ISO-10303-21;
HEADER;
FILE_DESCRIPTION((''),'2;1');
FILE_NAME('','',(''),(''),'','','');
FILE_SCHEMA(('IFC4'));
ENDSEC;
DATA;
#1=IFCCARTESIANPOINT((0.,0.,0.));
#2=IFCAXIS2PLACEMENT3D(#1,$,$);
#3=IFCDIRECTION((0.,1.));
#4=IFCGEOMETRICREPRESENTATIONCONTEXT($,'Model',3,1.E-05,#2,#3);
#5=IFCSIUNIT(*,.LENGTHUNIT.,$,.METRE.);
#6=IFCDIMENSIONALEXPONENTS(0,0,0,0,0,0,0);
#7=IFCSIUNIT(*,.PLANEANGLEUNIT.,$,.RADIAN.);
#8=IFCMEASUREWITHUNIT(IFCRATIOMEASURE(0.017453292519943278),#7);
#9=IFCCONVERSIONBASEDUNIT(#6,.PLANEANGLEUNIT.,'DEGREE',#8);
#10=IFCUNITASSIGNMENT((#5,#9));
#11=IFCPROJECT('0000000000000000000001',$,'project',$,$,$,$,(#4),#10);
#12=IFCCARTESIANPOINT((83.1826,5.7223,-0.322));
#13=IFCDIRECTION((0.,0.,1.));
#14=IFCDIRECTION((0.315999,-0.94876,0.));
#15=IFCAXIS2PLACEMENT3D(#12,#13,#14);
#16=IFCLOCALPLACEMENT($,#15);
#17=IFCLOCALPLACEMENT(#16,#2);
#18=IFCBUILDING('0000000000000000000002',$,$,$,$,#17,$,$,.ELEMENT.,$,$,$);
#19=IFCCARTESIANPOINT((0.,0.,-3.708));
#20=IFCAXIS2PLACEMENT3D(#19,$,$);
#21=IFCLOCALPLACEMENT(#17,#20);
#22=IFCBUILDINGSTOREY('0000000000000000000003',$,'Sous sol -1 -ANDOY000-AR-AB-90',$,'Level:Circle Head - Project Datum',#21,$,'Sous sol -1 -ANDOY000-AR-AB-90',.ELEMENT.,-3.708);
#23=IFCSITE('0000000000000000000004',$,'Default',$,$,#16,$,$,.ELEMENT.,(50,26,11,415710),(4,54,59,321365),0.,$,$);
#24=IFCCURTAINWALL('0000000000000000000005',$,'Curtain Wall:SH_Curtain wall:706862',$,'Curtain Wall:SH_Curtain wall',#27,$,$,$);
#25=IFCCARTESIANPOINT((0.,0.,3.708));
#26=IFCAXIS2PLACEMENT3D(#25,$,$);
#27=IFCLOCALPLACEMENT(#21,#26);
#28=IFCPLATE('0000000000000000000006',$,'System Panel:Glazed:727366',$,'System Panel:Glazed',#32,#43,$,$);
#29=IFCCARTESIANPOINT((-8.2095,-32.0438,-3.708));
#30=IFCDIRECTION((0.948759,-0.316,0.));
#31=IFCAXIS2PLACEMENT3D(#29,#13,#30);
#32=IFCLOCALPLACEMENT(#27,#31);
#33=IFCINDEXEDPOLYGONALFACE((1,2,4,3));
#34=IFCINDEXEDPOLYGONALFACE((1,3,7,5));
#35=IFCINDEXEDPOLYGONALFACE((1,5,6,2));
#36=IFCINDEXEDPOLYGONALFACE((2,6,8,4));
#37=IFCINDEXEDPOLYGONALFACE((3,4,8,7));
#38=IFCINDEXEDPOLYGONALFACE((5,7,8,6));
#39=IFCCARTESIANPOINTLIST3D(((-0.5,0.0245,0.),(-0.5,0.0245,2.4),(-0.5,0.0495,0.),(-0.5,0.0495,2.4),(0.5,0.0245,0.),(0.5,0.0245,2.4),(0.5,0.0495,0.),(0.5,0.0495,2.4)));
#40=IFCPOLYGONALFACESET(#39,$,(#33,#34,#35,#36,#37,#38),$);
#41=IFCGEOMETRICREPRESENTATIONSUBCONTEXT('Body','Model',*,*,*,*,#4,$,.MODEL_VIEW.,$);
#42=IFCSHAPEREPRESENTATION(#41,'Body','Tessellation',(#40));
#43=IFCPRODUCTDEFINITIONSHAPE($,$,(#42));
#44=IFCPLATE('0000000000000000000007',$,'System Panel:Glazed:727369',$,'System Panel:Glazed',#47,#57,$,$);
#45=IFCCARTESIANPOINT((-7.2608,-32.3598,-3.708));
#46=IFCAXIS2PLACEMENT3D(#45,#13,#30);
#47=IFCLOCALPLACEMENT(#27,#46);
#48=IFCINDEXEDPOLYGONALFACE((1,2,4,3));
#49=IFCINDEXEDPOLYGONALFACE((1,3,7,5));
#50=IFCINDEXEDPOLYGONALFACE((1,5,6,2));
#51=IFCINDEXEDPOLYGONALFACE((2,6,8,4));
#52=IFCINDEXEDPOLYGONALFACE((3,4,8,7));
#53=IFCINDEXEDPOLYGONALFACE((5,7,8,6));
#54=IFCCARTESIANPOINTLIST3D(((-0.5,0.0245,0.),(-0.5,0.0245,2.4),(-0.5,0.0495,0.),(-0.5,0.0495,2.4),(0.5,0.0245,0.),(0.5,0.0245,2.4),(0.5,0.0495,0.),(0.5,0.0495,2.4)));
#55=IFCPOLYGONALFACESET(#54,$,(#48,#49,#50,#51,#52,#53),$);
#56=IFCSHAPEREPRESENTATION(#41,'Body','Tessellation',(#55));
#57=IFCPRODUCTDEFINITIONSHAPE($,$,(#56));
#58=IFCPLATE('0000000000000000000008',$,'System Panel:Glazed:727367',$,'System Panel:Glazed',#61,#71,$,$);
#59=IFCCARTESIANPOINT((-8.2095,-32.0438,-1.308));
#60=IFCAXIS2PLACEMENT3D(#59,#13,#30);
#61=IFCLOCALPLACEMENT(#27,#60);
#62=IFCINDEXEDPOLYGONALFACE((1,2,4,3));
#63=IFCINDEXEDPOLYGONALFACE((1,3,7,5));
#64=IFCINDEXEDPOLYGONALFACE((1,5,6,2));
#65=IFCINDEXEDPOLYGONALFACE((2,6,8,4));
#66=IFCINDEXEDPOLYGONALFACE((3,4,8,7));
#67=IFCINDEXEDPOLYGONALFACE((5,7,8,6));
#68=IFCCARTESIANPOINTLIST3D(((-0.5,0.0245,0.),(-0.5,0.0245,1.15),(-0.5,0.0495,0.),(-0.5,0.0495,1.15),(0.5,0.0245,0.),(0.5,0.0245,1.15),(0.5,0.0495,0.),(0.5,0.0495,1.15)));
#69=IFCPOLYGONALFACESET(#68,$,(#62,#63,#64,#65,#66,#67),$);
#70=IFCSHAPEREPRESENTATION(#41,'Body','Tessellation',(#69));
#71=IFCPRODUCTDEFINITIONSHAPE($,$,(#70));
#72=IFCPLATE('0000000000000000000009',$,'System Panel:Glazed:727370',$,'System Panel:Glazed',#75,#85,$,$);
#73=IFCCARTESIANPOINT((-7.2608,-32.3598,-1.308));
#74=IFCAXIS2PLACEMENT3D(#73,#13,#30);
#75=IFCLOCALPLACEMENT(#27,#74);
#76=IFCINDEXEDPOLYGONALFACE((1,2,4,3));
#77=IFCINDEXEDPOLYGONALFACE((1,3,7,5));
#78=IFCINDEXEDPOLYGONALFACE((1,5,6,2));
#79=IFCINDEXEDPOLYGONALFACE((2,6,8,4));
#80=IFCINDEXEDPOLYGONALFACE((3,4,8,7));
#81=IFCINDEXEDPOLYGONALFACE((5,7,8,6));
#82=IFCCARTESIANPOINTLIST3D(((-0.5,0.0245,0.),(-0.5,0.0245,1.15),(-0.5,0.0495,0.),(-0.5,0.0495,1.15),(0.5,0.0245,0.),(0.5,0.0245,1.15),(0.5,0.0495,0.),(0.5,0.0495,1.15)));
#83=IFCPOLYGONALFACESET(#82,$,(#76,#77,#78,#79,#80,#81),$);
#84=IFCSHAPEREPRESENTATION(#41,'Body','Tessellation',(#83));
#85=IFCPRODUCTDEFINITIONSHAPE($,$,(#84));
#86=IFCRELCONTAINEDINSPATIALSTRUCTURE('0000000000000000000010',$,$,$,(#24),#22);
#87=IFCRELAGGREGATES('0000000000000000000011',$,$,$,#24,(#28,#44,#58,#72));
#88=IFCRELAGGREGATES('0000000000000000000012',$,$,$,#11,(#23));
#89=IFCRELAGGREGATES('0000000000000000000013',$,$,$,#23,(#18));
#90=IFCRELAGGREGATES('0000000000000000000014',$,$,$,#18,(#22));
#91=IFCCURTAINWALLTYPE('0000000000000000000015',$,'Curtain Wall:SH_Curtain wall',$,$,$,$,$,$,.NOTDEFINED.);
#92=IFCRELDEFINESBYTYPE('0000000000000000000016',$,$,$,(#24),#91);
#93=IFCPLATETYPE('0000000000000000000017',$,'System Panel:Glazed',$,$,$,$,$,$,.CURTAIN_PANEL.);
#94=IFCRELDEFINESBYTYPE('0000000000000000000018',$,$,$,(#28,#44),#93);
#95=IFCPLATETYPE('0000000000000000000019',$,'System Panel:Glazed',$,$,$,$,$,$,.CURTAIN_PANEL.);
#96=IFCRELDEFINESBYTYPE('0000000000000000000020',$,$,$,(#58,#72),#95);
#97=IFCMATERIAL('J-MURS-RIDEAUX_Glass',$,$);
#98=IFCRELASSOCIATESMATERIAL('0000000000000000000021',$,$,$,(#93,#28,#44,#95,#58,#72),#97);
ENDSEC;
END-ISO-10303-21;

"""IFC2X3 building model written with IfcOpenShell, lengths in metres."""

from ifc_helpers import new_model, entity, si_unit, converted_unit, direction, frame, frame_2d, origin, origin_2d_with_axis, place, context, subcontext, project, spatial, rectangle, extrude, source, transform, mapped, material, type_object, type_shapes, element, aggregate, save


model = new_model("IFC2X3")

# Units and contexts
model_context = context("Model", 3, precision=1e-05, world=origin(), true_north=direction((0.0, 1.0)))
body_context = subcontext(model_context, "Body", "Model", "MODEL_VIEW")
ifc_project = project(units=[si_unit("LENGTHUNIT", "METRE"), converted_unit("PLANEANGLEUNIT", "DEGREE", entity("IfcRatioMeasure", 0.017453292519943278), si_unit("PLANEANGLEUNIT", "RADIAN"), dimensions=[0, 0, 0, 0, 0, 0, 0])], contexts=[model_context])

# Site, building, storey
site_placement = place(None, frame((83.1826, 5.7223, -0.322), z_axis=(0.0, 0.0, 1.0), x_axis=(0.315999, -0.94876, 0.0)))
site = spatial("IfcSite", under=ifc_project, at=site_placement, Name="Default", CompositionType="ELEMENT", RefLatitude=(50, 26, 11, 415710), RefLongitude=(4, 54, 59, 321365), RefElevation=0.0)
building_placement = place(site_placement, origin())
building = spatial("IfcBuilding", under=site, at=building_placement, CompositionType="ELEMENT")
storey_placement = place(building_placement, frame((0.0, 0.0, -3.708)))
storey = spatial("IfcBuildingStorey", under=building, at=storey_placement, Name="Sous sol -1 -ANDOY000-AR-AB-90", ObjectType="Level:Circle Head - Project Datum", LongName="Sous sol -1 -ANDOY000-AR-AB-90", CompositionType="ELEMENT", Elevation=-3.708)

# Curtain wall
curtain_wall_type = type_object("IfcCurtainWallType", Name="Curtain Wall:SH_Curtain wall", PredefinedType="NOTDEFINED")
curtain_wall_1_placement = place(storey_placement, frame((0.0, 0.0, 3.708)))
curtain_wall_1 = element("IfcCurtainWall", 1, at=curtain_wall_1_placement, inside=storey, type_object=curtain_wall_type, Name="Curtain Wall:SH_Curtain wall:706862", ObjectType="Curtain Wall:SH_Curtain wall")

# Plates
ifc_material_1 = material(Name="J-MURS-RIDEAUX_Glass")
plate_type_1 = type_object("IfcPlateType", Name="System Panel:Glazed", PredefinedType="CURTAIN_PANEL", material=ifc_material_1)
shared_shape_1 = source(origin(), body_context, "Body", "SweptSolid", [
    extrude(rectangle(XDim=0.025, YDim=1.0, at=frame_2d((0.0, 0.0), x_axis=(1.0, 0.0))), frame((0.0, 0.037, 0.0), z_axis=(0.0, 0.0, 1.0), x_axis=(0.0, 1.0, 0.0)), (0.0, 0.0, 1.0), 2.4),
])
type_shapes(plate_type_1, [shared_shape_1])
plate_1_placement = place(curtain_wall_1_placement, frame((-8.2095, -32.0438, -3.708), z_axis=(0.0, 0.0, 1.0), x_axis=(0.948759, -0.316, 0.0)))
plate_1 = element("IfcPlate", 2, at=plate_1_placement, type_object=plate_type_1, material=ifc_material_1, Name="System Panel:Glazed:727366", ObjectType="System Panel:Glazed", context=body_context, shape_type="MappedRepresentation", body=[
    mapped(shared_shape_1, transform((0.0, 0.0, 0.0), scale=1.0)),
])
plate_2_placement = place(curtain_wall_1_placement, frame((-7.2608, -32.3598, -3.708), z_axis=(0.0, 0.0, 1.0), x_axis=(0.948759, -0.316, 0.0)))
plate_2 = element("IfcPlate", 3, at=plate_2_placement, type_object=plate_type_1, material=ifc_material_1, Name="System Panel:Glazed:727369", ObjectType="System Panel:Glazed", context=body_context, shape_type="MappedRepresentation", body=[
    mapped(shared_shape_1, transform((0.0, 0.0, 0.0), scale=1.0)),
])
plate_type_2 = type_object("IfcPlateType", Name="System Panel:Glazed", PredefinedType="CURTAIN_PANEL", material=ifc_material_1)
shared_shape_2 = source(origin(), body_context, "Body", "SweptSolid", [
    extrude(rectangle(XDim=0.025, YDim=1.0, at=origin_2d_with_axis()), frame((0.0, 0.037, 0.0), z_axis=(0.0, 0.0, 1.0), x_axis=(0.0, 1.0, 0.0)), (0.0, 0.0, 1.0), 1.15),
])
type_shapes(plate_type_2, [shared_shape_2])
plate_3_placement = place(curtain_wall_1_placement, frame((-8.2095, -32.0438, -1.308), z_axis=(0.0, 0.0, 1.0), x_axis=(0.948759, -0.316, 0.0)))
plate_3 = element("IfcPlate", 4, at=plate_3_placement, type_object=plate_type_2, material=ifc_material_1, Name="System Panel:Glazed:727367", ObjectType="System Panel:Glazed", context=body_context, shape_type="MappedRepresentation", body=[
    mapped(shared_shape_2, transform((0.0, 0.0, 0.0), scale=1.0)),
])
plate_4_placement = place(curtain_wall_1_placement, frame((-7.2608, -32.3598, -1.308), z_axis=(0.0, 0.0, 1.0), x_axis=(0.948759, -0.316, 0.0)))
plate_4 = element("IfcPlate", 5, at=plate_4_placement, type_object=plate_type_2, material=ifc_material_1, Name="System Panel:Glazed:727370", ObjectType="System Panel:Glazed", context=body_context, shape_type="MappedRepresentation", body=[
    mapped(shared_shape_2, transform((0.0, 0.0, 0.0), scale=1.0)),
])
aggregate(curtain_wall_1, [plate_1, plate_2, plate_3, plate_4])

save(model, "model.ifc")
